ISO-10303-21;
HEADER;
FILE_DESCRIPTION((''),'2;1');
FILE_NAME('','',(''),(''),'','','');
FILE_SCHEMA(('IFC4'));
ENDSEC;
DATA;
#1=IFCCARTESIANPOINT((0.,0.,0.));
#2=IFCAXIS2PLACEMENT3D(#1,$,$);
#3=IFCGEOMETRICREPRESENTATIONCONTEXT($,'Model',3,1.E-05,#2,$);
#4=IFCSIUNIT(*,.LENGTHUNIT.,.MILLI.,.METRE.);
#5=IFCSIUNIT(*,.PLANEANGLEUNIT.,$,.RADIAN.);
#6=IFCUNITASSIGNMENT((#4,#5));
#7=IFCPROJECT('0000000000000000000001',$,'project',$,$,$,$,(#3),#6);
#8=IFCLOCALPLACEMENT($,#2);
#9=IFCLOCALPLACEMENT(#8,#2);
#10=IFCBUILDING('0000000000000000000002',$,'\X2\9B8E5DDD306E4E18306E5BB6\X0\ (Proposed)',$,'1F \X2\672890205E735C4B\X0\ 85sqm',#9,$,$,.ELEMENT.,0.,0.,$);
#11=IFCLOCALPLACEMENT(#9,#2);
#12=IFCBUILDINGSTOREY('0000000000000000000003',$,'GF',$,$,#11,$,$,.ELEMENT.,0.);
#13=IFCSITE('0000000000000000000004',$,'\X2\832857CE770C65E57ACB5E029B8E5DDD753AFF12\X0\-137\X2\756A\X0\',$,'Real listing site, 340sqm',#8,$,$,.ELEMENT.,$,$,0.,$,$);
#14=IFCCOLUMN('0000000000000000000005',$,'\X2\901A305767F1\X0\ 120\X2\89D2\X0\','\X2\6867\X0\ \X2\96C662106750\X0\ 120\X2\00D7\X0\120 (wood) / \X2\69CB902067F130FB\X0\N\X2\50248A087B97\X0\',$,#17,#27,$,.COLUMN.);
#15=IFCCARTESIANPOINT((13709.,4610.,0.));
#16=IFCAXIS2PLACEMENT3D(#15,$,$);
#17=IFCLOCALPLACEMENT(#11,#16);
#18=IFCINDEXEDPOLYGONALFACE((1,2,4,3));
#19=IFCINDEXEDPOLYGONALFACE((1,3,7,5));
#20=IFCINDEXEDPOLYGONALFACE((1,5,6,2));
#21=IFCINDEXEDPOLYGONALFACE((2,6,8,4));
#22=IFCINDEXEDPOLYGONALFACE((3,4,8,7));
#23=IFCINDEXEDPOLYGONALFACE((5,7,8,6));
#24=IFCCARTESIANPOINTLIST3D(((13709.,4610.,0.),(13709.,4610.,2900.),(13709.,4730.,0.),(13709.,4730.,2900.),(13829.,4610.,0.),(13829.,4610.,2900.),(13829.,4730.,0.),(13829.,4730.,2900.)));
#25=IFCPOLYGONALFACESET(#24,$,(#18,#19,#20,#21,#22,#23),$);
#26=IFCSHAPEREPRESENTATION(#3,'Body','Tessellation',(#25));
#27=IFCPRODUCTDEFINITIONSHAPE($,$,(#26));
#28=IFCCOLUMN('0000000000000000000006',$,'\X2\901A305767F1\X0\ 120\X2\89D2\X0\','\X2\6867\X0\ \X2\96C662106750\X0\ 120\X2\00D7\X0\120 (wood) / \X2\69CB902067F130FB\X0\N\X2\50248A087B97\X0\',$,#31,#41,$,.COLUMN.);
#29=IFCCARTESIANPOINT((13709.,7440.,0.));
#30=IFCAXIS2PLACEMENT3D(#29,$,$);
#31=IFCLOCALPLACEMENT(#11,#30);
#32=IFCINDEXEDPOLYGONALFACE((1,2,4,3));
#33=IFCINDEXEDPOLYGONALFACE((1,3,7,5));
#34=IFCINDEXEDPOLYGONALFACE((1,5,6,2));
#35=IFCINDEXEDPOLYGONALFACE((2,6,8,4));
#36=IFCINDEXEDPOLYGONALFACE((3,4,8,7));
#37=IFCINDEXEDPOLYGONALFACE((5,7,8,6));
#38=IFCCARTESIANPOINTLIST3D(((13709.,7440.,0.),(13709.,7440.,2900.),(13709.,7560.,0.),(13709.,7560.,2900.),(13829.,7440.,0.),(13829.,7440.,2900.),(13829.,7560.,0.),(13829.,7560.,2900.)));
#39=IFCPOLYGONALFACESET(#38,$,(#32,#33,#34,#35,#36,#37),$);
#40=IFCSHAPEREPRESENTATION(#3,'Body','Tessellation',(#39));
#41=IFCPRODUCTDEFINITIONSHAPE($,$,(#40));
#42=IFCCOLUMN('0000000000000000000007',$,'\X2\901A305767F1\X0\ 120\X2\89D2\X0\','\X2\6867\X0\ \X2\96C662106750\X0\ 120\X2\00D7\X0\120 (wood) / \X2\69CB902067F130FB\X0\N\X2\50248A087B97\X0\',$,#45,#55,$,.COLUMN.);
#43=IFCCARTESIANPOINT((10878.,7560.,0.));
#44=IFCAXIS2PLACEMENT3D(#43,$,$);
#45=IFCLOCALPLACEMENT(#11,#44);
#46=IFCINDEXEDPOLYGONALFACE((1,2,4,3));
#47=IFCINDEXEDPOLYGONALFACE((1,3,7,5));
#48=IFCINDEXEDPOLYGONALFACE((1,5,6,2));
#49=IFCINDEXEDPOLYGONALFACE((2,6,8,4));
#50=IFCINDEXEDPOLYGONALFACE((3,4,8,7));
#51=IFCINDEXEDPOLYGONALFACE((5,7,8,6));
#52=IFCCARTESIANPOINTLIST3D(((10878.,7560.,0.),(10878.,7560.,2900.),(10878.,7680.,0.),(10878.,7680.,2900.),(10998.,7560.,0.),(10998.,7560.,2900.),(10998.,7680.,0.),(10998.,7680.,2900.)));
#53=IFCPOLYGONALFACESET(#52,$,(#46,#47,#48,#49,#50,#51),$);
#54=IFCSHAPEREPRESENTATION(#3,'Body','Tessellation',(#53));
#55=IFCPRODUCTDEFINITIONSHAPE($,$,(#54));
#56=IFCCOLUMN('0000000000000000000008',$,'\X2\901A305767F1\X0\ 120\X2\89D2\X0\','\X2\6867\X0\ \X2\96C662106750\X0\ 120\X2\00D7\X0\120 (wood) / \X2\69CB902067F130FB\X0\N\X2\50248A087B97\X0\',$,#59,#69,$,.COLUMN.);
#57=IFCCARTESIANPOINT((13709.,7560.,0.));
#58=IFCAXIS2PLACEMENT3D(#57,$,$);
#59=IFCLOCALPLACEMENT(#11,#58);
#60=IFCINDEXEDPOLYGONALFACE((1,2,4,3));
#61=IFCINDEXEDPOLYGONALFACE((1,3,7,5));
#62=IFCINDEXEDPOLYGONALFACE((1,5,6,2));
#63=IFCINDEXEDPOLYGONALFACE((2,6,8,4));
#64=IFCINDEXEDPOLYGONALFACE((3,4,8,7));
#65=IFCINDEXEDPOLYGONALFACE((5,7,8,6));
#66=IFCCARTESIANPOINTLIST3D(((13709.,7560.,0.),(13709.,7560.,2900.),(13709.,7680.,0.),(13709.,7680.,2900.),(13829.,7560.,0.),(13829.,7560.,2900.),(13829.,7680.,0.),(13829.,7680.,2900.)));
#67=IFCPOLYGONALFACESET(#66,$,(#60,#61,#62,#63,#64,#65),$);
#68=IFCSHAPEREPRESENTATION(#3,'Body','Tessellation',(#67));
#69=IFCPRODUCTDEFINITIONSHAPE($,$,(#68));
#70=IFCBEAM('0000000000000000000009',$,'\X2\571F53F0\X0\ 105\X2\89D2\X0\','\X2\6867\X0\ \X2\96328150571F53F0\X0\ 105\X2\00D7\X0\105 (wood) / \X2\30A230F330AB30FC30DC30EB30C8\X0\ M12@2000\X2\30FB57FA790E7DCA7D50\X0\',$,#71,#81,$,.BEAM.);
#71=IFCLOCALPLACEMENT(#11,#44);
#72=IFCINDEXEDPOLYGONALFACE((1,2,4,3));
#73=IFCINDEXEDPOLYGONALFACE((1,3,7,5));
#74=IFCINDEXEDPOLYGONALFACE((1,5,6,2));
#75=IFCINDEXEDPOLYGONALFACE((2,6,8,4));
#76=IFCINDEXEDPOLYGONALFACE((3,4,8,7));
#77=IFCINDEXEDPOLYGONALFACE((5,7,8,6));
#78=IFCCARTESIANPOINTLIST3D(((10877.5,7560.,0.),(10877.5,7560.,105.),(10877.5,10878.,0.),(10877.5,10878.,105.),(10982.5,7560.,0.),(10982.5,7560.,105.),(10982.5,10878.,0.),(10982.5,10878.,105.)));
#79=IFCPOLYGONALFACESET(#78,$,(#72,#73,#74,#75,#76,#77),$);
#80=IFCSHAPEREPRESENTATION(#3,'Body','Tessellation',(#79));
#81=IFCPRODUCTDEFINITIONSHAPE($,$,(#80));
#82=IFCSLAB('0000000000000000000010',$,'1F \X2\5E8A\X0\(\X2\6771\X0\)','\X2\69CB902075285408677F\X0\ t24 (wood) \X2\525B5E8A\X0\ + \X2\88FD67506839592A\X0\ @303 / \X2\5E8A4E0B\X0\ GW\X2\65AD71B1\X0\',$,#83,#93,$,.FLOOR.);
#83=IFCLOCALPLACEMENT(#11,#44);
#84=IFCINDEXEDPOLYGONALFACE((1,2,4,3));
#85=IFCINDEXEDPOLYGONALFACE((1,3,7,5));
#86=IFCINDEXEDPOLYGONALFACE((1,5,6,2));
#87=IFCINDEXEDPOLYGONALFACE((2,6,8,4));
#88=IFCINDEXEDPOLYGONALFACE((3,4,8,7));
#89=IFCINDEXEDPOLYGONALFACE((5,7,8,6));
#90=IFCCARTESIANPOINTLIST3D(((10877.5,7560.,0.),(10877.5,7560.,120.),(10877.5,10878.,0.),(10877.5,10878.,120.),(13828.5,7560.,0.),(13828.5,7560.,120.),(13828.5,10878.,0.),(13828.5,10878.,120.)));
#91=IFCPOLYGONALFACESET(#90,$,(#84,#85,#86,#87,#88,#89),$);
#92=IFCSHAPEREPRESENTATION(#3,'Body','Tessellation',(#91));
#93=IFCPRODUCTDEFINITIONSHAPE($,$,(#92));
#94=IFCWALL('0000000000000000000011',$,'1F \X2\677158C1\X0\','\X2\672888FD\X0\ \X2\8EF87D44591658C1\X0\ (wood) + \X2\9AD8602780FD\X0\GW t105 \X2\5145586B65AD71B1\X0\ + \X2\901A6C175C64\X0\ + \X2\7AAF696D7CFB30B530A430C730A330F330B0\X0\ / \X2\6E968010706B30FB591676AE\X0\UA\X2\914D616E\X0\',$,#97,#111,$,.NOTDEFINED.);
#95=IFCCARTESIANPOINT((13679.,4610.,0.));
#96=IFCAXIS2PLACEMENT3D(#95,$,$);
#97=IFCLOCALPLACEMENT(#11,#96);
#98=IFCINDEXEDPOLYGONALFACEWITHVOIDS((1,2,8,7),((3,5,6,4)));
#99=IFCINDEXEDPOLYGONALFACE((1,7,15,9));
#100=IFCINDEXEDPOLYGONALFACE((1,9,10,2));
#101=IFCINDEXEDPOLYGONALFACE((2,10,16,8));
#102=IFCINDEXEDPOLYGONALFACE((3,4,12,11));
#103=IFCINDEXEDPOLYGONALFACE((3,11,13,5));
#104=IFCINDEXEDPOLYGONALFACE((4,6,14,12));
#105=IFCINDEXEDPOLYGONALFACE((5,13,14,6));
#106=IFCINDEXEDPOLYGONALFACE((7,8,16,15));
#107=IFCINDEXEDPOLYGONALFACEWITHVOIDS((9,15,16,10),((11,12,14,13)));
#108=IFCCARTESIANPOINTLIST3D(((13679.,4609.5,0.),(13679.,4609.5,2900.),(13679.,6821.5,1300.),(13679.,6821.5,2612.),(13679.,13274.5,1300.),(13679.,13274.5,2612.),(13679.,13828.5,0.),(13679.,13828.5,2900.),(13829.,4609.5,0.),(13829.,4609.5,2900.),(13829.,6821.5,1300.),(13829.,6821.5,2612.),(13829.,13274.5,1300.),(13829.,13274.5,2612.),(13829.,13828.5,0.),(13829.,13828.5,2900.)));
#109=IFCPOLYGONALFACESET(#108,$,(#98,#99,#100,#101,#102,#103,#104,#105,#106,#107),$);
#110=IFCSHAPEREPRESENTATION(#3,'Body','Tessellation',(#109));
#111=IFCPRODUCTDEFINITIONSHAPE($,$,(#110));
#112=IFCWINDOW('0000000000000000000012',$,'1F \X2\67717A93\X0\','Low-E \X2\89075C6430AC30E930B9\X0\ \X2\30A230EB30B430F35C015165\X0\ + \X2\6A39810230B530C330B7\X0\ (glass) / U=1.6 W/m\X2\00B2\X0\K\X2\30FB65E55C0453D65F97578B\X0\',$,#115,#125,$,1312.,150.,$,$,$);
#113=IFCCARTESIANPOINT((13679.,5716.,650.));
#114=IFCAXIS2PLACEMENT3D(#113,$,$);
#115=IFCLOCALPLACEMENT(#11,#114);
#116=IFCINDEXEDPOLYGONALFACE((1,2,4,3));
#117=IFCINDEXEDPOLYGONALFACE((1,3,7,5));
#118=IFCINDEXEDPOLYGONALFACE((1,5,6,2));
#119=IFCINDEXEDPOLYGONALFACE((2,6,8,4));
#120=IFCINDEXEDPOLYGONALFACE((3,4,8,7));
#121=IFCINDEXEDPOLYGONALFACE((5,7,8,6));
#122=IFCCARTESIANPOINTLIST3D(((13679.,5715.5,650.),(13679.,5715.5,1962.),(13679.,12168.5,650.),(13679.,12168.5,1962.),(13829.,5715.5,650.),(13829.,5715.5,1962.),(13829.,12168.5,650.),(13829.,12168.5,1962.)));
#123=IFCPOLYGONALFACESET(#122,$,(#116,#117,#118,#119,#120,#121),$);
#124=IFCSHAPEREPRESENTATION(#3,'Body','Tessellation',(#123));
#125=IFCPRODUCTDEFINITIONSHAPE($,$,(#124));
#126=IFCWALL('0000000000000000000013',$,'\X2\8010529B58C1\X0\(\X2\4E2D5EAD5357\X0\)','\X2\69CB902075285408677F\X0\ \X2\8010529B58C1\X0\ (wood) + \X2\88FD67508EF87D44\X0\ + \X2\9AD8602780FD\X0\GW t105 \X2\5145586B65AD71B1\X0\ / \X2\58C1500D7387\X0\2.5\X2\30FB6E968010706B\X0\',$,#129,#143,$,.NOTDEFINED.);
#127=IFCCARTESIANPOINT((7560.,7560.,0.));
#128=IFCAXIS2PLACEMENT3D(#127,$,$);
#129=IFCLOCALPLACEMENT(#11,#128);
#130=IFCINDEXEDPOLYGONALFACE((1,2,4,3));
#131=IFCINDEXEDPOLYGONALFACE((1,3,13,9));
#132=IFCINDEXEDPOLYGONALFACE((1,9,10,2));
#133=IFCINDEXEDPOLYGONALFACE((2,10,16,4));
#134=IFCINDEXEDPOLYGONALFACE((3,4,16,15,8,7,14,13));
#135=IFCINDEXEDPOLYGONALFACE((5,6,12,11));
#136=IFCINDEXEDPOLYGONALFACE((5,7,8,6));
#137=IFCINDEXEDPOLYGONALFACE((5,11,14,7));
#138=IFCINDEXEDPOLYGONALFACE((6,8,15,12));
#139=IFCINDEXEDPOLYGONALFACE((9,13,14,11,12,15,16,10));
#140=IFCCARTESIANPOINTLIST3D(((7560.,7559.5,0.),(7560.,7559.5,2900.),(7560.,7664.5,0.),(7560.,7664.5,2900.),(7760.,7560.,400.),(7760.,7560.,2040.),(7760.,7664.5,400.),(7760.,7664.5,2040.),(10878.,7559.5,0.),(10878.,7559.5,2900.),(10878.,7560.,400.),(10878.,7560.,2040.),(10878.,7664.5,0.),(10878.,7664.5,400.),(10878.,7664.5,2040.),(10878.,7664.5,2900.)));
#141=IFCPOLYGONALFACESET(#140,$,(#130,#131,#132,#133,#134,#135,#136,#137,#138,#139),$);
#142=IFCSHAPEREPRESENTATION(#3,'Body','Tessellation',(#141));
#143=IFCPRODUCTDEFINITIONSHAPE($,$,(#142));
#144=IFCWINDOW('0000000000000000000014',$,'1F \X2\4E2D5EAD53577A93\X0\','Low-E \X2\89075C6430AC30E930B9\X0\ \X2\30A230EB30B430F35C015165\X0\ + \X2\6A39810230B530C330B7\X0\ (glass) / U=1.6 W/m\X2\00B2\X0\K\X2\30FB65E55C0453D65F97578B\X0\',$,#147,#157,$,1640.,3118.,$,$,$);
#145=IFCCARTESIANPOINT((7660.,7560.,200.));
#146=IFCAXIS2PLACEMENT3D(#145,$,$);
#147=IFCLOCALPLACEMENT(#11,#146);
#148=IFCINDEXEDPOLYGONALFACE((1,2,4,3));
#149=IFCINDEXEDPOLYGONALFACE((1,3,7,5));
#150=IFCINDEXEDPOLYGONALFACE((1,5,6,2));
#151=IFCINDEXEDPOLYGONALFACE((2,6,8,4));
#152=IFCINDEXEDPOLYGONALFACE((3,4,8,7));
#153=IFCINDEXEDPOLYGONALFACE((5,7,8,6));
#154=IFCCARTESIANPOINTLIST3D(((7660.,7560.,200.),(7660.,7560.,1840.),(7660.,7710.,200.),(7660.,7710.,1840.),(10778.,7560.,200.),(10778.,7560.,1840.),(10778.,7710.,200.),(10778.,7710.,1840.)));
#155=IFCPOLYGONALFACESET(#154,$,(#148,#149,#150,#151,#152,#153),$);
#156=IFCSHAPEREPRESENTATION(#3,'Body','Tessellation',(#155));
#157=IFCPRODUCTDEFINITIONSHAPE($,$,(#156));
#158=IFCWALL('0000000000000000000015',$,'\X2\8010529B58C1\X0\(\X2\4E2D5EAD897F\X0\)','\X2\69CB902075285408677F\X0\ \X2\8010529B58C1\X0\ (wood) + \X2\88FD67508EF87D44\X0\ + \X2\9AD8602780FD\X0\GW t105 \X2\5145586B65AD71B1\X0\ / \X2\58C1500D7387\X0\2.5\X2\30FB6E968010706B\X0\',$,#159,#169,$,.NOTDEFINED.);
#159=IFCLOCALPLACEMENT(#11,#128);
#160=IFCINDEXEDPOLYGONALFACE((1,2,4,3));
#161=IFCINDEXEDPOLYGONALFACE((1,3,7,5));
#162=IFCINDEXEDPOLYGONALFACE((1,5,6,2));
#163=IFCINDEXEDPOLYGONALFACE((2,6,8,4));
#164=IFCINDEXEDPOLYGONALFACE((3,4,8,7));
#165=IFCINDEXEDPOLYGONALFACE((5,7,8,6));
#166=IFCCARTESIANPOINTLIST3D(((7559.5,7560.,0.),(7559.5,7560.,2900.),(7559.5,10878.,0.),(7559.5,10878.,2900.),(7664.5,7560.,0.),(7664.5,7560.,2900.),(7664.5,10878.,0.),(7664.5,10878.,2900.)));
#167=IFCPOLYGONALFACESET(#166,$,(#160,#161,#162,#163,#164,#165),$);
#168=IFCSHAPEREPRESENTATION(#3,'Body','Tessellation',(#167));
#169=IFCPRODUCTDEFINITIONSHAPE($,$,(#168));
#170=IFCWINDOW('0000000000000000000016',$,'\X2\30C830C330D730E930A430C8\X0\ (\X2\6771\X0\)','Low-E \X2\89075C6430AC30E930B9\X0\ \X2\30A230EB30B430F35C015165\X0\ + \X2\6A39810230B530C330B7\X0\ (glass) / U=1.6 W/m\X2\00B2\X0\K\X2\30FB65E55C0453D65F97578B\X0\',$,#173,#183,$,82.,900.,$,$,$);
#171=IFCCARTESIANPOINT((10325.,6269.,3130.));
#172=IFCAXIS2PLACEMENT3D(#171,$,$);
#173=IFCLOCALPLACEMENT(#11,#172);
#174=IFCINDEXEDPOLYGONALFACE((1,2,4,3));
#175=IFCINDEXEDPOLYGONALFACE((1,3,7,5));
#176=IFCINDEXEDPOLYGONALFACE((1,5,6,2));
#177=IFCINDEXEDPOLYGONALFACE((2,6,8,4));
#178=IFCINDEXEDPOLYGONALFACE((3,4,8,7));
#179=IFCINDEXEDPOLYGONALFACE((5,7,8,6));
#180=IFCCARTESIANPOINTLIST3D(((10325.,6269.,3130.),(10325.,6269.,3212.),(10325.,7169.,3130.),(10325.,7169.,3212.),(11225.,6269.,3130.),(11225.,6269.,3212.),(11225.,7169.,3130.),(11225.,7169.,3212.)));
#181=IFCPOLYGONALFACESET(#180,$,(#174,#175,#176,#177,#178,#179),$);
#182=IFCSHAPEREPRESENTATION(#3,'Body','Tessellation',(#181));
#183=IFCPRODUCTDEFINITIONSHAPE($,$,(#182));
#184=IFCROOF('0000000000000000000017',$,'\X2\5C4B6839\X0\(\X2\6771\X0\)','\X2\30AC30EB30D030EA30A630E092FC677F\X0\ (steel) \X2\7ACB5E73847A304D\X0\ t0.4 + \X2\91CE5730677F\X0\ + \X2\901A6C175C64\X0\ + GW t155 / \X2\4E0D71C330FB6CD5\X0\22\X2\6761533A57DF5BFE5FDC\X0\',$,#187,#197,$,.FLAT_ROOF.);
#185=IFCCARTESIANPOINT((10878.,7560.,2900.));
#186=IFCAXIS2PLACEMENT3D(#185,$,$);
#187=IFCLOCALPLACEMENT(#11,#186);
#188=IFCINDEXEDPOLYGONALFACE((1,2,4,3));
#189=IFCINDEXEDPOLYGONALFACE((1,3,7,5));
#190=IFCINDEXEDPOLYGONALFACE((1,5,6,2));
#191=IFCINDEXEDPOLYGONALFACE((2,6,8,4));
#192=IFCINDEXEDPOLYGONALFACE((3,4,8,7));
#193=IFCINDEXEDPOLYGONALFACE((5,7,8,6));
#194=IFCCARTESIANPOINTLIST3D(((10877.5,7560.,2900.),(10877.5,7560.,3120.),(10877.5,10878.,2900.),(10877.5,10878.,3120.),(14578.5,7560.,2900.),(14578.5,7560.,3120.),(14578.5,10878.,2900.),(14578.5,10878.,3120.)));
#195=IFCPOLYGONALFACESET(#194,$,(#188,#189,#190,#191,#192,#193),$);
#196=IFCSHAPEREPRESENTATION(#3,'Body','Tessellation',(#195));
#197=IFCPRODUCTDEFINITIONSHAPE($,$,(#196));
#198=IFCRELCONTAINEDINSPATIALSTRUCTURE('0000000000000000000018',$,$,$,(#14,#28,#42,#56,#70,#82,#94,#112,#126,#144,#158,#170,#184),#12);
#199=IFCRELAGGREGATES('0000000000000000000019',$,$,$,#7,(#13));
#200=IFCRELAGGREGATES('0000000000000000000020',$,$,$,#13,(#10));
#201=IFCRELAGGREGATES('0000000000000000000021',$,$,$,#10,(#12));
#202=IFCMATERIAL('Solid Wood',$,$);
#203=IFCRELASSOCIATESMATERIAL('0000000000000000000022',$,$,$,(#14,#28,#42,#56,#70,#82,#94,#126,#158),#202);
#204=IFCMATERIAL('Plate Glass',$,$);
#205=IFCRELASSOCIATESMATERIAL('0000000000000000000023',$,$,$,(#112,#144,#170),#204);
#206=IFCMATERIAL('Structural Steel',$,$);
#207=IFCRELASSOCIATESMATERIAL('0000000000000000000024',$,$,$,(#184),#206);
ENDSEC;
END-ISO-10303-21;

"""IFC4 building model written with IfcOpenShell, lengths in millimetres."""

from ifc_helpers import new_model, si_unit, frame, frame_2d, origin, place, context, project, spatial, rectangle, extrude, material, element, fill, save


model = new_model("IFC4")

# Units and contexts
model_context = context("Model", 3, precision=1e-05, world=origin())
ifc_project = project(units=[si_unit("LENGTHUNIT", "METRE", prefix="MILLI"), si_unit("PLANEANGLEUNIT", "RADIAN")], contexts=[model_context])

# Site, building, storey
site_placement = place(None, origin())
site = spatial("IfcSite", under=ifc_project, at=site_placement, Name="茨城県日立市鮎川町２-137番", ObjectType="Real listing site, 340sqm", CompositionType="ELEMENT", RefElevation=0.0)
building_placement = place(site_placement, origin())
building = spatial("IfcBuilding", under=site, at=building_placement, Name="鮎川の丘の家 (Proposed)", ObjectType="1F 木造平屋 85sqm", CompositionType="ELEMENT", ElevationOfRefHeight=0.0, ElevationOfTerrain=0.0)
storey_placement = place(building_placement, origin())
storey = spatial("IfcBuildingStorey", under=building, at=storey_placement, Name="GF", CompositionType="ELEMENT", Elevation=0.0)

# Columns
ifc_material_1 = material(Name="Solid Wood")
column_1_placement = place(storey_placement, frame((13709.0, 4610.0, 0.0)))
element("IfcColumn", 1, at=column_1_placement, inside=storey, material=ifc_material_1, Name="通し柱 120角", Description="桧 集成材 120×120 (wood) / 構造柱・N値計算", PredefinedType="COLUMN", context=model_context, shape_type="SweptSolid", body=[
    extrude(rectangle(XDim=120.0, YDim=120.0, at=frame_2d((60.0, 60.0))), frame((13709.0, 4610.0, 0.0)), (0.0, 0.0, 1.0), 2900.0),
])
column_2_placement = place(storey_placement, frame((13709.0, 7440.0, 0.0)))
element("IfcColumn", 2, at=column_2_placement, inside=storey, material=ifc_material_1, Name="通し柱 120角", Description="桧 集成材 120×120 (wood) / 構造柱・N値計算", PredefinedType="COLUMN", context=model_context, shape_type="SweptSolid", body=[
    extrude(rectangle(XDim=120.0, YDim=120.0, at=frame_2d((60.0, 60.0))), frame((13709.0, 7440.0, 0.0)), (0.0, 0.0, 1.0), 2900.0),
])
column_3_placement = place(storey_placement, frame((10878.0, 7560.0, 0.0)))
element("IfcColumn", 3, at=column_3_placement, inside=storey, material=ifc_material_1, Name="通し柱 120角", Description="桧 集成材 120×120 (wood) / 構造柱・N値計算", PredefinedType="COLUMN", context=model_context, shape_type="SweptSolid", body=[
    extrude(rectangle(XDim=120.0, YDim=120.0, at=frame_2d((60.0, 60.0))), frame((10878.0, 7560.0, 0.0)), (0.0, 0.0, 1.0), 2900.0),
])
column_4_placement = place(storey_placement, frame((13709.0, 7560.0, 0.0)))
element("IfcColumn", 4, at=column_4_placement, inside=storey, material=ifc_material_1, Name="通し柱 120角", Description="桧 集成材 120×120 (wood) / 構造柱・N値計算", PredefinedType="COLUMN", context=model_context, shape_type="SweptSolid", body=[
    extrude(rectangle(XDim=120.0, YDim=120.0, at=frame_2d((60.0, 60.0))), frame((13709.0, 7560.0, 0.0)), (0.0, 0.0, 1.0), 2900.0),
])

# Beam
beam_1_placement = place(storey_placement, frame((10878.0, 7560.0, 0.0)))
element("IfcBeam", 5, at=beam_1_placement, inside=storey, material=ifc_material_1, Name="土台 105角", Description="桧 防腐土台 105×105 (wood) / アンカーボルト M12@2000・基礎緊結", PredefinedType="BEAM", context=model_context, shape_type="SweptSolid", body=[
    extrude(rectangle(XDim=105.0, YDim=3318.0, at=frame_2d((52.0, 1659.0))), frame((10878.0, 7560.0, 0.0)), (0.0, 0.0, 1.0), 105.0),
])

# Slab
slab_placement = place(storey_placement, frame((10878.0, 7560.0, 0.0)))
element("IfcSlab", 6, at=slab_placement, inside=storey, material=ifc_material_1, Name="1F 床(東)", Description="構造用合板 t24 (wood) 剛床 + 製材根太 @303 / 床下 GW断熱", PredefinedType="FLOOR", context=model_context, shape_type="SweptSolid", body=[
    extrude(rectangle(XDim=2951.0, YDim=3318.0, at=frame_2d((1475.0, 1659.0))), frame((10878.0, 7560.0, 0.0)), (0.0, 0.0, 1.0), 120.0),
])

# Walls, openings, windows
wall_1_placement = place(storey_placement, frame((13679.0, 4610.0, 0.0)))
wall_1 = element("IfcWall", 7, at=wall_1_placement, inside=storey, material=ifc_material_1, Name="1F 東壁", Description="木製 軸組外壁 (wood) + 高性能GW t105 充填断熱 + 通気層 + 窯業系サイディング / 準耐火・外皮UA配慮", PredefinedType="NOTDEFINED", context=model_context, shape_type="SweptSolid", body=[
    extrude(rectangle(XDim=150.0, YDim=9219.0, at=frame_2d((75.0, 4609.0))), frame((13679.0, 4610.0, 0.0)), (0.0, 0.0, 1.0), 2900.0),
])
opening_1_placement = place(storey_placement, frame((13679.0, 5716.0, 650.0)))
opening_1 = element("IfcOpeningElement", 8, at=opening_1_placement, cuts=wall_1, PredefinedType="NOTDEFINED", context=model_context, shape_type="SweptSolid", body=[
    extrude(rectangle(XDim=150.0, YDim=6453.0, at=frame_2d((75.0, 3226.0))), frame((13679.0, 5716.0, 650.0)), (0.0, 0.0, 1.0), 1312.0),
])
ifc_material_2 = material(Name="Plate Glass")
window_1_placement = place(storey_placement, frame((13679.0, 5716.0, 650.0)))
window_1 = element("IfcWindow", 9, at=window_1_placement, inside=storey, material=ifc_material_2, Name="1F 東窓", Description="Low-E 複層ガラス アルゴン封入 + 樹脂サッシ (glass) / U=1.6 W/m²K・日射取得型", OverallHeight=1312.0, OverallWidth=150.0, context=model_context, shape_type="SweptSolid", body=[
    extrude(rectangle(XDim=150.0, YDim=6453.0, at=frame_2d((75.0, 3226.0))), frame((13679.0, 5716.0, 650.0)), (0.0, 0.0, 1.0), 1312.0),
])
fill(opening_1, window_1)
wall_2_placement = place(storey_placement, frame((7560.0, 7560.0, 0.0)))
wall_2 = element("IfcWall", 10, at=wall_2_placement, inside=storey, material=ifc_material_1, Name="耐力壁(中庭南)", Description="構造用合板 耐力壁 (wood) + 製材軸組 + 高性能GW t105 充填断熱 / 壁倍率2.5・準耐火", PredefinedType="NOTDEFINED", context=model_context, shape_type="SweptSolid", body=[
    extrude(rectangle(XDim=3318.0, YDim=105.0, at=frame_2d((1659.0, 52.0))), frame((7560.0, 7560.0, 0.0)), (0.0, 0.0, 1.0), 2900.0),
])
opening_2_placement = place(storey_placement, frame((7660.0, 7560.0, 200.0)))
opening_2 = element("IfcOpeningElement", 11, at=opening_2_placement, cuts=wall_2, PredefinedType="NOTDEFINED", context=model_context, shape_type="SweptSolid", body=[
    extrude(rectangle(XDim=3118.0, YDim=150.0, at=frame_2d((1559.0, 75.0))), frame((7660.0, 7560.0, 200.0)), (0.0, 0.0, 1.0), 1640.0),
])
window_2_placement = place(storey_placement, frame((7660.0, 7560.0, 200.0)))
window_2 = element("IfcWindow", 12, at=window_2_placement, inside=storey, material=ifc_material_2, Name="1F 中庭南窓", Description="Low-E 複層ガラス アルゴン封入 + 樹脂サッシ (glass) / U=1.6 W/m²K・日射取得型", OverallHeight=1640.0, OverallWidth=3118.0, context=model_context, shape_type="SweptSolid", body=[
    extrude(rectangle(XDim=3118.0, YDim=150.0, at=frame_2d((1559.0, 75.0))), frame((7660.0, 7560.0, 200.0)), (0.0, 0.0, 1.0), 1640.0),
])
fill(opening_2, window_2)

# Wall
wall_3_placement = place(storey_placement, frame((7560.0, 7560.0, 0.0)))
element("IfcWall", 13, at=wall_3_placement, inside=storey, material=ifc_material_1, Name="耐力壁(中庭西)", Description="構造用合板 耐力壁 (wood) + 製材軸組 + 高性能GW t105 充填断熱 / 壁倍率2.5・準耐火", PredefinedType="NOTDEFINED", context=model_context, shape_type="SweptSolid", body=[
    extrude(rectangle(XDim=105.0, YDim=3318.0, at=frame_2d((52.0, 1659.0))), frame((7560.0, 7560.0, 0.0)), (0.0, 0.0, 1.0), 2900.0),
])

# Window
window_3_placement = place(storey_placement, frame((10325.0, 6269.0, 3130.0)))
element("IfcWindow", 14, at=window_3_placement, inside=storey, material=ifc_material_2, Name="トップライト (東)", Description="Low-E 複層ガラス アルゴン封入 + 樹脂サッシ (glass) / U=1.6 W/m²K・日射取得型", OverallHeight=82.0, OverallWidth=900.0, context=model_context, shape_type="SweptSolid", body=[
    extrude(rectangle(XDim=900.0, YDim=900.0, at=frame_2d((450.0, 450.0))), frame((10325.0, 6269.0, 3130.0)), (0.0, 0.0, 1.0), 82.0),
])

# Roof
ifc_material_3 = material(Name="Structural Steel")
roof_placement = place(storey_placement, frame((10878.0, 7560.0, 2900.0)))
element("IfcRoof", 15, at=roof_placement, inside=storey, material=ifc_material_3, Name="屋根(東)", Description="ガルバリウム鋼板 (steel) 立平葺き t0.4 + 野地板 + 通気層 + GW t155 / 不燃・法22条区域対応", PredefinedType="FLAT_ROOF", context=model_context, shape_type="SweptSolid", body=[
    extrude(rectangle(XDim=3701.0, YDim=3318.0, at=frame_2d((1850.0, 1659.0))), frame((10878.0, 7560.0, 2900.0)), (0.0, 0.0, 1.0), 220.0),
])

save(model, "model.ifc")
